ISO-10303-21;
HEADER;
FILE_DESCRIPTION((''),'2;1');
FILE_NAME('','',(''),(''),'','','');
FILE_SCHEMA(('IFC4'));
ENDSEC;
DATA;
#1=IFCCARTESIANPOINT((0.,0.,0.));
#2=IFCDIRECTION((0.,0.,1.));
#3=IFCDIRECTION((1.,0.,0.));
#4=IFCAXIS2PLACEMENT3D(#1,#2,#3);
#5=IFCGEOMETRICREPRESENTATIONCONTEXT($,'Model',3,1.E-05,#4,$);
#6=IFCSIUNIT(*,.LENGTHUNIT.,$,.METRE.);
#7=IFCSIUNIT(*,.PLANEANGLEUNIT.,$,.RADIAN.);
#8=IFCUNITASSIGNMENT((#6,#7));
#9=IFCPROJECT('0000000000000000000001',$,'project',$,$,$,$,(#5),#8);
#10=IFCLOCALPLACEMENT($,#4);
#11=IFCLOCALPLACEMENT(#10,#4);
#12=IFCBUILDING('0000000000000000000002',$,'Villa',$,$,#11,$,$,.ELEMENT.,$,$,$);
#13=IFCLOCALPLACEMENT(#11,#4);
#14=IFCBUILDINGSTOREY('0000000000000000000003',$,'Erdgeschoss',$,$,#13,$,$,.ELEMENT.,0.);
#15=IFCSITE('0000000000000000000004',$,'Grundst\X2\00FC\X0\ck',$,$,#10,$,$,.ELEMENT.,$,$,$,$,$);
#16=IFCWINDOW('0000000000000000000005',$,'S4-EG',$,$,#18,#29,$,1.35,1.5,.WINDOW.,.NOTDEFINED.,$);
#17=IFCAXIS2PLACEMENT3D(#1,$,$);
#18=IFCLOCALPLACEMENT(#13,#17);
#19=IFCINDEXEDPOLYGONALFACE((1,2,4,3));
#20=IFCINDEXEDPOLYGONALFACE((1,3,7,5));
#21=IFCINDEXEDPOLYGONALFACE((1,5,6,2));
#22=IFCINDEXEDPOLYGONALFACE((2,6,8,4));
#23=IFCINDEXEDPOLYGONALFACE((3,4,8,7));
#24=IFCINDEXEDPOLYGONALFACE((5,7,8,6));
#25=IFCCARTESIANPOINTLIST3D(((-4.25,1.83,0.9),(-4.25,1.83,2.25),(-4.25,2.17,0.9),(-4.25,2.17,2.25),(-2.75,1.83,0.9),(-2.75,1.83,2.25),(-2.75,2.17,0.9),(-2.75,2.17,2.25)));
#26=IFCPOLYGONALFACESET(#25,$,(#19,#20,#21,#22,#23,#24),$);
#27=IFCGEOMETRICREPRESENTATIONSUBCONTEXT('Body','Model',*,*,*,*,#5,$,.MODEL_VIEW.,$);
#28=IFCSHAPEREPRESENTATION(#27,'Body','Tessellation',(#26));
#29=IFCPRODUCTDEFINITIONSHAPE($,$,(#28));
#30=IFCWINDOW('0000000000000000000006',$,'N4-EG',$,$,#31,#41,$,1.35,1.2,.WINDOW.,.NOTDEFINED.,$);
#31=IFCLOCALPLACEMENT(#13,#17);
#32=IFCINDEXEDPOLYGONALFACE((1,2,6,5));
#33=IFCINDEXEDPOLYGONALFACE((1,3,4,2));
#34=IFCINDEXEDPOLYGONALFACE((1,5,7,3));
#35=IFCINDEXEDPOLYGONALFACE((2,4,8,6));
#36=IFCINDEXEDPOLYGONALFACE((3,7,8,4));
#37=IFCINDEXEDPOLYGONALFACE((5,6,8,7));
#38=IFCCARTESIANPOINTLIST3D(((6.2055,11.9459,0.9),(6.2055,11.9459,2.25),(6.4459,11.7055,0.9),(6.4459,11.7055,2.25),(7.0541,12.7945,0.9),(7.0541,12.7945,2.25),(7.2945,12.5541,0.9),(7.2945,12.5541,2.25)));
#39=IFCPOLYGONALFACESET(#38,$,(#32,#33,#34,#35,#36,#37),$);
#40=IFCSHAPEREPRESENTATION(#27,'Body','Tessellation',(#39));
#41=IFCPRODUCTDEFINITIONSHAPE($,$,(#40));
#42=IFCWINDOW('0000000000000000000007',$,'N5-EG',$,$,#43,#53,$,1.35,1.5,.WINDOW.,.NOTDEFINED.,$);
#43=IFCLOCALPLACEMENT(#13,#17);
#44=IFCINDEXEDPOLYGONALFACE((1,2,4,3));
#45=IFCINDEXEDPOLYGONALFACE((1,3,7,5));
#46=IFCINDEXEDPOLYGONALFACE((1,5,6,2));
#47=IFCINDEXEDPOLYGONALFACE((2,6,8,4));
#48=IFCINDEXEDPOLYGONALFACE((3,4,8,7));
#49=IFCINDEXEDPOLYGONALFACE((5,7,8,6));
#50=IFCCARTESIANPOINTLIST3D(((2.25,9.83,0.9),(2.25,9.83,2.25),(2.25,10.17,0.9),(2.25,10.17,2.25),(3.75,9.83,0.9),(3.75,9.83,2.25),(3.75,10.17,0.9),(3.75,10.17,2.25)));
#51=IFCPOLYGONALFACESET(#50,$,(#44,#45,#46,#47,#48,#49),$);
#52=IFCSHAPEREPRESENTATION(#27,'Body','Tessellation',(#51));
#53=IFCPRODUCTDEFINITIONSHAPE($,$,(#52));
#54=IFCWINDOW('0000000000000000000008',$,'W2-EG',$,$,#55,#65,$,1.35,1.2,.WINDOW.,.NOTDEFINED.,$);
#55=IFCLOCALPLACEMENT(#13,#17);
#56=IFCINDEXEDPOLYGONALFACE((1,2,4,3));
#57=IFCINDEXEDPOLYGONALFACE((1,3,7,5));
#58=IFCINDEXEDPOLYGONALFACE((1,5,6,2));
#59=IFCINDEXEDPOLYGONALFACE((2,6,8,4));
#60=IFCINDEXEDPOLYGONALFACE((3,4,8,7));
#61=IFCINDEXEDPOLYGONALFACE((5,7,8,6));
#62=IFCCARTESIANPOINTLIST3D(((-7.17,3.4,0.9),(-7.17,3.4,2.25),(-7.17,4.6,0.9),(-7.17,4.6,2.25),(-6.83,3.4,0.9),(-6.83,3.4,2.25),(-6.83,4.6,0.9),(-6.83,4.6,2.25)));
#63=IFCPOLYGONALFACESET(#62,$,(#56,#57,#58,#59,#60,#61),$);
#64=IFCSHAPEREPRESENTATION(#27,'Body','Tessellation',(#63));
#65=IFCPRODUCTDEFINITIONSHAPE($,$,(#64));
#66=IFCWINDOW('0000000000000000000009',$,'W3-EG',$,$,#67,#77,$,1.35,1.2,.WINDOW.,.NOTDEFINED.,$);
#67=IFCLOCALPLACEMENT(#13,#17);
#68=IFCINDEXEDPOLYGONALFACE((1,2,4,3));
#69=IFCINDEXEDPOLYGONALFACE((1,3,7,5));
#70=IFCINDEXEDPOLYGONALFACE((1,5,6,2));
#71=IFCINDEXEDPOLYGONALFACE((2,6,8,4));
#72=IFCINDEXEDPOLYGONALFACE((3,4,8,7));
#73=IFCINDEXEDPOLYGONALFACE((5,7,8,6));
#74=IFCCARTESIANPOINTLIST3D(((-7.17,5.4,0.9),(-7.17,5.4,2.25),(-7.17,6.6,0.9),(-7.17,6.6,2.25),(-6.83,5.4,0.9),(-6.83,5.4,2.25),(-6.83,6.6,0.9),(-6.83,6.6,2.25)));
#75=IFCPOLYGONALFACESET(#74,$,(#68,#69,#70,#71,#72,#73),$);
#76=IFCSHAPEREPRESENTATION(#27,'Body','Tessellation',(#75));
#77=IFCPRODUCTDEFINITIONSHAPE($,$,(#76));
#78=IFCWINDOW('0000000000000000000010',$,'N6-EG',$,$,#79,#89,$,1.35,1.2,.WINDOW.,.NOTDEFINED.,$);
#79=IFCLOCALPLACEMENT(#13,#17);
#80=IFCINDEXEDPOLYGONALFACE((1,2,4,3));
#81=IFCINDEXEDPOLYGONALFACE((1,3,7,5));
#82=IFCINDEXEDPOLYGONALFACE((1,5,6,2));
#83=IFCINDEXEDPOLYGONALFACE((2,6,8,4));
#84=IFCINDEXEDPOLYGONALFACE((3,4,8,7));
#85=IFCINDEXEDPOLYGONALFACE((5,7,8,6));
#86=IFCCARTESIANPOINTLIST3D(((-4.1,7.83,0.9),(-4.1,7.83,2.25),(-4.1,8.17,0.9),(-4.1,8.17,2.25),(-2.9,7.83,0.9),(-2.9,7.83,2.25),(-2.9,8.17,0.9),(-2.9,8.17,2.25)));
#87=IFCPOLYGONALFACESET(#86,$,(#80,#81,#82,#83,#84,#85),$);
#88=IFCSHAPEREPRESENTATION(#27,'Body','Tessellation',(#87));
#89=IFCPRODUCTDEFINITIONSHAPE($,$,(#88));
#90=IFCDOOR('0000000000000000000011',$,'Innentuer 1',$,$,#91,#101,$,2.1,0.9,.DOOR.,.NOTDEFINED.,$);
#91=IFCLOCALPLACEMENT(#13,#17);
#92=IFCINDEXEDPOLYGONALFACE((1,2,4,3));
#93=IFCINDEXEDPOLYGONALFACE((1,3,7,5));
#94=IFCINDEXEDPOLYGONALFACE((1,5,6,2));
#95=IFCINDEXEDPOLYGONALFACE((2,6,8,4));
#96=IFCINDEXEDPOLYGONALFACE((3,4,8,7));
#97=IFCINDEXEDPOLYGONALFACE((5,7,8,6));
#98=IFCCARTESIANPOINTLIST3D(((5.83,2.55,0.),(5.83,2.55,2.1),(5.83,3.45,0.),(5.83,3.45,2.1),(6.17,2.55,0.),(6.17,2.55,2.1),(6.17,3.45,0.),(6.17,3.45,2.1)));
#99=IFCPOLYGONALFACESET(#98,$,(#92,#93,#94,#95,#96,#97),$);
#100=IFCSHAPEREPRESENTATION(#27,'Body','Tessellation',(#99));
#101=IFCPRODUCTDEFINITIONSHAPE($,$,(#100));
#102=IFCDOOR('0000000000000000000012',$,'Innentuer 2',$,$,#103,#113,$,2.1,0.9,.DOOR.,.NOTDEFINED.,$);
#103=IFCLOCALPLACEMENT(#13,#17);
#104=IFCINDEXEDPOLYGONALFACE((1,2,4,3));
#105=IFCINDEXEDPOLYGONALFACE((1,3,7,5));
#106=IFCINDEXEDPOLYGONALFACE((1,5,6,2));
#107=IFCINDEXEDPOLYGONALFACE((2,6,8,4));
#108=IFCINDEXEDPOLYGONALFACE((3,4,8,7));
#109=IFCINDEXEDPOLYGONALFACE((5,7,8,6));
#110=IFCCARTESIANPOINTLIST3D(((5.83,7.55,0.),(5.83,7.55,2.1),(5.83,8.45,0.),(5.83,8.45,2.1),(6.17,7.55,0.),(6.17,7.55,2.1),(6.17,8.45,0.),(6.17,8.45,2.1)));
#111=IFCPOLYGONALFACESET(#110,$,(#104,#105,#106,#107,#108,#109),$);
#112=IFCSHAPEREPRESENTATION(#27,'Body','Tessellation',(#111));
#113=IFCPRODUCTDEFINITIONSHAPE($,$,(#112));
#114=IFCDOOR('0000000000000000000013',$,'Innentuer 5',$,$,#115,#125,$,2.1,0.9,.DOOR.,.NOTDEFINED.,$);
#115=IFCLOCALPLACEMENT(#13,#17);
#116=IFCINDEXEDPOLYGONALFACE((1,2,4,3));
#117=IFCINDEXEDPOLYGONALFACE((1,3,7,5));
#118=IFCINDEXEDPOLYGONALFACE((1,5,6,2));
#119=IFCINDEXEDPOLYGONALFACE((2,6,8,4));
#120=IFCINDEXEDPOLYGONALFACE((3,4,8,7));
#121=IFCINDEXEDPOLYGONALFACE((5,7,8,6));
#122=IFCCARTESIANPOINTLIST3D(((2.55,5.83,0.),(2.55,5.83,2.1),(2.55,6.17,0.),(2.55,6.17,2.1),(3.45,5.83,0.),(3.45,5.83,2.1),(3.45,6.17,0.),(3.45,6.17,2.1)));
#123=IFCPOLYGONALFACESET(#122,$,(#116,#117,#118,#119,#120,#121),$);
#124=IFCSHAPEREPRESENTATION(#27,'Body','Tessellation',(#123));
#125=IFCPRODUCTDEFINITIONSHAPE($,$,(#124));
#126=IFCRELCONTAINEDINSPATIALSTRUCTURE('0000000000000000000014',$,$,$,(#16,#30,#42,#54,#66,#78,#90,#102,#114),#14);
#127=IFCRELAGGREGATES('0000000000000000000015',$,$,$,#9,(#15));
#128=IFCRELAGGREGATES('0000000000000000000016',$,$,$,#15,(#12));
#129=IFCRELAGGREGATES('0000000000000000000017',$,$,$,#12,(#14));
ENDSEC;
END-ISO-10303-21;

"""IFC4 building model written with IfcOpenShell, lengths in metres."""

from ifc_helpers import new_model, si_unit, frame, origin_with_axes, origin_2d, place, context, subcontext, project, spatial, rectangle, extrude, element, save


model = new_model("IFC4")

# Units and contexts
model_context = context("Model", 3, precision=1e-05, world=origin_with_axes())
body_context = subcontext(model_context, "Body", "Model", "MODEL_VIEW")
ifc_project = project(units=[si_unit("LENGTHUNIT", "METRE"), si_unit("PLANEANGLEUNIT", "RADIAN")], contexts=[model_context])

# Site, building, storey
site_placement = place(None, origin_with_axes())
site = spatial("IfcSite", under=ifc_project, at=site_placement, Name="Grundstück", CompositionType="ELEMENT")
building_placement = place(site_placement, origin_with_axes())
building = spatial("IfcBuilding", under=site, at=building_placement, Name="Villa", CompositionType="ELEMENT")
storey_placement = place(building_placement, origin_with_axes())
storey = spatial("IfcBuildingStorey", under=building, at=storey_placement, Name="Erdgeschoss", CompositionType="ELEMENT", Elevation=0.0)

# Windows
window_1_placement = place(storey_placement, frame((-3.5, 2.0, 0.9), z_axis=(0.0, 0.0, 1.0), x_axis=(1.0, 0.0, 0.0)))
element("IfcWindow", 1, at=window_1_placement, inside=storey, Name="S4-EG", OverallHeight=1.35, OverallWidth=1.5, PartitioningType="NOTDEFINED", PredefinedType="WINDOW", context=body_context, shape_type="SweptSolid", body=[
    extrude(rectangle(XDim=1.5, YDim=0.34, at=origin_2d()), origin_with_axes(), (0.0, 0.0, 1.0), 1.35),
])
window_2_placement = place(storey_placement, frame((6.75, 12.25, 0.9), z_axis=(0.0, 0.0, 1.0), x_axis=(-0.7071, -0.7071, 0.0)))
element("IfcWindow", 2, at=window_2_placement, inside=storey, Name="N4-EG", OverallHeight=1.35, OverallWidth=1.2, PartitioningType="NOTDEFINED", PredefinedType="WINDOW", context=body_context, shape_type="SweptSolid", body=[
    extrude(rectangle(XDim=1.2, YDim=0.34, at=origin_2d()), origin_with_axes(), (0.0, 0.0, 1.0), 1.35),
])
window_3_placement = place(storey_placement, frame((3.0, 10.0, 0.9), z_axis=(0.0, 0.0, 1.0), x_axis=(1.0, 0.0, 0.0)))
element("IfcWindow", 3, at=window_3_placement, inside=storey, Name="N5-EG", OverallHeight=1.35, OverallWidth=1.5, PartitioningType="NOTDEFINED", PredefinedType="WINDOW", context=body_context, shape_type="SweptSolid", body=[
    extrude(rectangle(XDim=1.5, YDim=0.34, at=origin_2d()), origin_with_axes(), (0.0, 0.0, 1.0), 1.35),
])
for number, where, z_axis, x_axis, name in (
    (4, (-7.0, 4.0, 0.9), (0.0, 0.0, 1.0), (0.0, 1.0, 0.0), "W2-EG"),
    (5, (-7.0, 6.0, 0.9), (0.0, 0.0, 1.0), (0.0, 1.0, 0.0), "W3-EG"),
    (6, (-3.5, 8.0, 0.9), (0.0, 0.0, 1.0), (1.0, 0.0, 0.0), "N6-EG"),
):
    element("IfcWindow", number, at=place(storey_placement, frame(where, z_axis=z_axis, x_axis=x_axis)), inside=storey, Name=name, OverallHeight=1.35, OverallWidth=1.2, PartitioningType="NOTDEFINED", PredefinedType="WINDOW", context=body_context, shape_type="SweptSolid", body=[
        extrude(rectangle(XDim=1.2, YDim=0.34, at=origin_2d()), origin_with_axes(), (0.0, 0.0, 1.0), 1.35),
    ])

# Doors
for number, where, z_axis, x_axis, name in (
    (7, (6.0, 3.0, 0.0), (0.0, 0.0, 1.0), (0.0, 1.0, 0.0), "Innentuer 1"),
    (8, (6.0, 8.0, 0.0), (0.0, 0.0, 1.0), (0.0, 1.0, 0.0), "Innentuer 2"),
    (9, (3.0, 6.0, 0.0), (0.0, 0.0, 1.0), (1.0, 0.0, 0.0), "Innentuer 5"),
):
    element("IfcDoor", number, at=place(storey_placement, frame(where, z_axis=z_axis, x_axis=x_axis)), inside=storey, Name=name, OperationType="NOTDEFINED", OverallHeight=2.1, OverallWidth=0.9, PredefinedType="DOOR", context=body_context, shape_type="SweptSolid", body=[
        extrude(rectangle(XDim=0.9, YDim=0.34, at=origin_2d()), origin_with_axes(), (0.0, 0.0, 1.0), 2.1),
    ])

save(model, "model.ifc")
